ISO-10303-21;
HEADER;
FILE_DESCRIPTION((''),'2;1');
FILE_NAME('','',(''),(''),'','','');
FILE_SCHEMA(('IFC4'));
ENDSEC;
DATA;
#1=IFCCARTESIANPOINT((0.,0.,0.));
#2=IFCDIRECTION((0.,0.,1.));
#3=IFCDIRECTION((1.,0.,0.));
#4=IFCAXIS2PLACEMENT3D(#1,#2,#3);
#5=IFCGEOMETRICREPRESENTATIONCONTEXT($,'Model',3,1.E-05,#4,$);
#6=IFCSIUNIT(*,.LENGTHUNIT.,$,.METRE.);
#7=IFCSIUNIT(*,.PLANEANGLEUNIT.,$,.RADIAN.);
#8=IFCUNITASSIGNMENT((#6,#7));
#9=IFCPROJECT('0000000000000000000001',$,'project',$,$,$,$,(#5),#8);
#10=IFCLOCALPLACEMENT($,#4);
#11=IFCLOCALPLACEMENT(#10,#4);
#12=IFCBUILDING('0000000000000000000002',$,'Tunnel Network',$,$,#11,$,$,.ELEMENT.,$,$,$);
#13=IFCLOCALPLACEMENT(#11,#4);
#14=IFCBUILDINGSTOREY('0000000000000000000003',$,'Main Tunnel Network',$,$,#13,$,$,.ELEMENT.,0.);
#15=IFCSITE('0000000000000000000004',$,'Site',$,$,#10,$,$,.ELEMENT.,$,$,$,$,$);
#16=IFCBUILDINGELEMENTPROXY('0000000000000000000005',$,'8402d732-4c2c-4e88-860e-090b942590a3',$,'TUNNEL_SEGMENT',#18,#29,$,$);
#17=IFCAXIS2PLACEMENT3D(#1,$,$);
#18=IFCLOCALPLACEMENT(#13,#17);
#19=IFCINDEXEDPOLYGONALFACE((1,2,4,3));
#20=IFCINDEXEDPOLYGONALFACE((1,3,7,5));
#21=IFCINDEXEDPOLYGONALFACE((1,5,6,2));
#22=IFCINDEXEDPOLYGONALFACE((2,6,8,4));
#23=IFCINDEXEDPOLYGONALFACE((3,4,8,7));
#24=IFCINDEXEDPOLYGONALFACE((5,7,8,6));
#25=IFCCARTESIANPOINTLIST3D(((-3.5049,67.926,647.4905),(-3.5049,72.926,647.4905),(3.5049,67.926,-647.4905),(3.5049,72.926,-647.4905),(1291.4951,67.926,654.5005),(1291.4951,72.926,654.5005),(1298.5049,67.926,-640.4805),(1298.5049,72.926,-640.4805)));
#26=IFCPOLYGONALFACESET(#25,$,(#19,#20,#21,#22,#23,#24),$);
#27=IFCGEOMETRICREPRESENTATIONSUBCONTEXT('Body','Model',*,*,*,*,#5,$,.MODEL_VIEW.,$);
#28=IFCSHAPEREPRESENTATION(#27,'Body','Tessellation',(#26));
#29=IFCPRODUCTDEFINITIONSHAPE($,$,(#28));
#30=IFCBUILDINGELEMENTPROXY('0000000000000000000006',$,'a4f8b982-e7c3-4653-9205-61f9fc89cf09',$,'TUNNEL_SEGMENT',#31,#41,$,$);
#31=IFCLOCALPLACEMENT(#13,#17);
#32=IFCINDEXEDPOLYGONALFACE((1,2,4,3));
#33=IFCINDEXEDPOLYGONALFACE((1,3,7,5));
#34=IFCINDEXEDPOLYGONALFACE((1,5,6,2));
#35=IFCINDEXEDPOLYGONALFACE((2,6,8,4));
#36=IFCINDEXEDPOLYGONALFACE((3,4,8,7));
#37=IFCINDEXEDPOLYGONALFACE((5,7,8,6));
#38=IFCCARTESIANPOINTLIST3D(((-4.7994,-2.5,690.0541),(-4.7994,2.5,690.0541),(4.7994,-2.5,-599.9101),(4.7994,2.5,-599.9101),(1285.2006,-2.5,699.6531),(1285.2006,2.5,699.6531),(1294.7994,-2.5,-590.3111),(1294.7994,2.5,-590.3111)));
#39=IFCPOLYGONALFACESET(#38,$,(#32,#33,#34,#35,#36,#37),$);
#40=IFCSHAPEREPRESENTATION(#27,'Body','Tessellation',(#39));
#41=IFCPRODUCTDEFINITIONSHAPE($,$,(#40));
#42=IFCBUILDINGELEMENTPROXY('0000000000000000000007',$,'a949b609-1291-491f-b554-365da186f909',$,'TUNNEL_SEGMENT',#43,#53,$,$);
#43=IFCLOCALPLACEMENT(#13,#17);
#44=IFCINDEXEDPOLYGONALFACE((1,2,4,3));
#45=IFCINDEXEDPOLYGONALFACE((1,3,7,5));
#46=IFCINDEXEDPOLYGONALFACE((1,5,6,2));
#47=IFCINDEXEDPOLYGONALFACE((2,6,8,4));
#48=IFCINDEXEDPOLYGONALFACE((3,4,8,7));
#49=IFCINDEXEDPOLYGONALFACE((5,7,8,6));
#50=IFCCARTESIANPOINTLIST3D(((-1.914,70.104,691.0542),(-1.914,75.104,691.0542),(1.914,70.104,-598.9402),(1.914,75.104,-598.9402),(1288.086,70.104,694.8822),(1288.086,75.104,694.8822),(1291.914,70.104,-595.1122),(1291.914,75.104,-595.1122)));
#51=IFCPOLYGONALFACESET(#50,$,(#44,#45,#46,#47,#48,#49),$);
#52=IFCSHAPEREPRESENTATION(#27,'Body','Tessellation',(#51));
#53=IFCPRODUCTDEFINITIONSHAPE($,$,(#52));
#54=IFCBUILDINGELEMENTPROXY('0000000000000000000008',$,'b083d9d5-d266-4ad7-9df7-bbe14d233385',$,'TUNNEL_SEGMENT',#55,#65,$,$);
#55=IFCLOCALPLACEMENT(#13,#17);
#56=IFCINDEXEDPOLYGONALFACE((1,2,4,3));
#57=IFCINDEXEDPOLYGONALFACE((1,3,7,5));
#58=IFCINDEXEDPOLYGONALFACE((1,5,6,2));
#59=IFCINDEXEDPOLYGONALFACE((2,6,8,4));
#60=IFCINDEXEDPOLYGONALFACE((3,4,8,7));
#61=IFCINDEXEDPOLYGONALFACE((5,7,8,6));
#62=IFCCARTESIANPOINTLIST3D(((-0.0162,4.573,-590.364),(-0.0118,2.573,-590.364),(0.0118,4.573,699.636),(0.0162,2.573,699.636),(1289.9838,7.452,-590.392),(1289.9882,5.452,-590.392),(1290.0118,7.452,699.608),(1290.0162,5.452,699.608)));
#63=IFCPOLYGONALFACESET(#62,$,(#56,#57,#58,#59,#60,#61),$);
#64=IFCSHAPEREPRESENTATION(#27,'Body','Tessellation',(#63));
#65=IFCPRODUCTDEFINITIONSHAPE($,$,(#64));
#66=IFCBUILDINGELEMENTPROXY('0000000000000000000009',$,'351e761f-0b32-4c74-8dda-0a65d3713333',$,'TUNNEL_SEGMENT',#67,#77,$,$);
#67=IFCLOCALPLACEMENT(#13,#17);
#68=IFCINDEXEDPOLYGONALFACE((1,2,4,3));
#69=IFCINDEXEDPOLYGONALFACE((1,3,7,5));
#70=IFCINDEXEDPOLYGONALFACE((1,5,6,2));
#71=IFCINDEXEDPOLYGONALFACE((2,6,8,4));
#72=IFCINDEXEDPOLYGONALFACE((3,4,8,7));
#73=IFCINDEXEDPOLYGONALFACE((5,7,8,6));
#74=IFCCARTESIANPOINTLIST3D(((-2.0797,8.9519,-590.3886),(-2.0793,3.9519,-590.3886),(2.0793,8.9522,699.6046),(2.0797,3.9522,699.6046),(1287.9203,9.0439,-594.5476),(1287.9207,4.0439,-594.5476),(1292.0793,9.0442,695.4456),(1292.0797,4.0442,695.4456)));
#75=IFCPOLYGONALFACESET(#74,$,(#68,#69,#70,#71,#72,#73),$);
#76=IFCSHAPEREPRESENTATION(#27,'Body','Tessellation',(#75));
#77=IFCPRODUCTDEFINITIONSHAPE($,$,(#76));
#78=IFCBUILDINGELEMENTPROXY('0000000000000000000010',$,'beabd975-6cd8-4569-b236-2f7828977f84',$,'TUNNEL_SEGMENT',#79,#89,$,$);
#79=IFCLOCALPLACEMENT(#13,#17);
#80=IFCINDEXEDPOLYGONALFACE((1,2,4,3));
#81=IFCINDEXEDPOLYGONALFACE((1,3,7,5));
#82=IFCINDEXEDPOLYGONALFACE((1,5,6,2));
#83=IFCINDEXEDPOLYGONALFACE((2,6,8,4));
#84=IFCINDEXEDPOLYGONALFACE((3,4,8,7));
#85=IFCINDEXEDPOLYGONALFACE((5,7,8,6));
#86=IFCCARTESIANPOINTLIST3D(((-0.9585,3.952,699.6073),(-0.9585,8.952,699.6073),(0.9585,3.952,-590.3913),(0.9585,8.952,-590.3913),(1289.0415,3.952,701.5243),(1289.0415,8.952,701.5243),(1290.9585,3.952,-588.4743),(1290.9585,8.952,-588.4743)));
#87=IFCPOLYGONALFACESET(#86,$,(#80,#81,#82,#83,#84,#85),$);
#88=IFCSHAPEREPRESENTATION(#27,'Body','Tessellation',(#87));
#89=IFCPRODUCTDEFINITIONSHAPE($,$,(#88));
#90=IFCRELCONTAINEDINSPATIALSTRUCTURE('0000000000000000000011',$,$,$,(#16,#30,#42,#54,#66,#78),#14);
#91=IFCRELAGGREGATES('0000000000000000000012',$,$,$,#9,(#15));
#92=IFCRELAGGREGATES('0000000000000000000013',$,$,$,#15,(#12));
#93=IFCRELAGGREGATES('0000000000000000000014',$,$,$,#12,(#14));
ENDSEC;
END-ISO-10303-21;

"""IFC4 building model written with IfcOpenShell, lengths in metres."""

from ifc_helpers import new_model, si_unit, frame, origin_with_axes, origin_2d_with_axis, place, context, subcontext, project, spatial, rectangle, extrude, element, save


model = new_model("IFC4")

# Units and contexts
model_context = context("Model", 3, precision=1e-05, world=origin_with_axes())
body_context = subcontext(model_context, "Body", "Model", "MODEL_VIEW")
ifc_project = project(units=[si_unit("LENGTHUNIT", "METRE"), si_unit("PLANEANGLEUNIT", "RADIAN")], contexts=[model_context])

# Site, building, storey
site_placement = place(None, origin_with_axes())
site = spatial("IfcSite", under=ifc_project, at=site_placement, Name="Site", CompositionType="ELEMENT")
building_placement = place(site_placement, origin_with_axes())
building = spatial("IfcBuilding", under=site, at=building_placement, Name="Tunnel Network", CompositionType="ELEMENT")
storey_placement = place(building_placement, origin_with_axes())
storey = spatial("IfcBuildingStorey", under=building, at=storey_placement, Name="Main Tunnel Network", CompositionType="ELEMENT", Elevation=0.0)

# Building element proxies
proxy_1_placement = place(storey_placement, frame((0.0, 70.426, 0.0), z_axis=(0.999985, 0.0, 0.005413), x_axis=(-0.005413, 0.0, 0.999985)))
element("IfcBuildingElementProxy", 1, at=proxy_1_placement, inside=storey, Name="8402d732-4c2c-4e88-860e-090b942590a3", ObjectType="TUNNEL_SEGMENT", context=body_context, shape_type="SweptSolid", body=[
    extrude(rectangle(XDim=1295.0, YDim=5.0, at=origin_2d_with_axis()), origin_with_axes(), (0.0, 0.0, 1.0), 1295.019),
])
proxy_2_placement = place(storey_placement, frame((0.0, 0.0, 45.072), z_axis=(0.999972, 0.0, 0.007441), x_axis=(-0.007441, 0.0, 0.999972)))
element("IfcBuildingElementProxy", 2, at=proxy_2_placement, inside=storey, Name="a4f8b982-e7c3-4653-9205-61f9fc89cf09", ObjectType="TUNNEL_SEGMENT", context=body_context, shape_type="SweptSolid", body=[
    extrude(rectangle(XDim=1290.0, YDim=5.0, at=origin_2d_with_axis()), origin_with_axes(), (0.0, 0.0, 1.0), 1290.0357),
])
proxy_3_placement = place(storey_placement, frame((0.0, 72.604, 46.057), z_axis=(0.999996, 0.0, 0.002967), x_axis=(-0.002967, 0.0, 0.999996)))
element("IfcBuildingElementProxy", 3, at=proxy_3_placement, inside=storey, Name="a949b609-1291-491f-b554-365da186f909", ObjectType="TUNNEL_SEGMENT", context=body_context, shape_type="SweptSolid", body=[
    extrude(rectangle(XDim=1290.0, YDim=5.0, at=origin_2d_with_axis()), origin_with_axes(), (0.0, 0.0, 1.0), 1290.0057),
])
proxy_4_placement = place(storey_placement, frame((0.0, 3.573, 54.636), z_axis=(0.999998, 0.002232, -0.000022), x_axis=(0.000022, 0.0, 1.0)))
element("IfcBuildingElementProxy", 4, at=proxy_4_placement, inside=storey, Name="b083d9d5-d266-4ad7-9df7-bbe14d233385", ObjectType="TUNNEL_SEGMENT", context=body_context, shape_type="SweptSolid", body=[
    extrude(rectangle(XDim=1290.0, YDim=2.0, at=origin_2d_with_axis()), origin_with_axes(), (0.0, 0.0, 1.0), 1290.0032),
])
proxy_5_placement = place(storey_placement, frame((0.0, 6.452, 54.608), z_axis=(0.999995, 0.000071, -0.003224), x_axis=(0.003224, 0.0, 0.999995)))
element("IfcBuildingElementProxy", 5, at=proxy_5_placement, inside=storey, Name="351e761f-0b32-4c74-8dda-0a65d3713333", ObjectType="TUNNEL_SEGMENT", context=body_context, shape_type="SweptSolid", body=[
    extrude(rectangle(XDim=1290.0, YDim=5.0, at=origin_2d_with_axis()), origin_with_axes(), (0.0, 0.0, 1.0), 1290.0067),
])
proxy_6_placement = place(storey_placement, frame((0.0, 6.452, 54.608), z_axis=(0.999999, 0.0, 0.001486), x_axis=(-0.001486, 0.0, 0.999999)))
element("IfcBuildingElementProxy", 6, at=proxy_6_placement, inside=storey, Name="beabd975-6cd8-4569-b236-2f7828977f84", ObjectType="TUNNEL_SEGMENT", context=body_context, shape_type="SweptSolid", body=[
    extrude(rectangle(XDim=1290.0, YDim=5.0, at=origin_2d_with_axis()), origin_with_axes(), (0.0, 0.0, 1.0), 1290.0014),
])

save(model, "model.ifc")
